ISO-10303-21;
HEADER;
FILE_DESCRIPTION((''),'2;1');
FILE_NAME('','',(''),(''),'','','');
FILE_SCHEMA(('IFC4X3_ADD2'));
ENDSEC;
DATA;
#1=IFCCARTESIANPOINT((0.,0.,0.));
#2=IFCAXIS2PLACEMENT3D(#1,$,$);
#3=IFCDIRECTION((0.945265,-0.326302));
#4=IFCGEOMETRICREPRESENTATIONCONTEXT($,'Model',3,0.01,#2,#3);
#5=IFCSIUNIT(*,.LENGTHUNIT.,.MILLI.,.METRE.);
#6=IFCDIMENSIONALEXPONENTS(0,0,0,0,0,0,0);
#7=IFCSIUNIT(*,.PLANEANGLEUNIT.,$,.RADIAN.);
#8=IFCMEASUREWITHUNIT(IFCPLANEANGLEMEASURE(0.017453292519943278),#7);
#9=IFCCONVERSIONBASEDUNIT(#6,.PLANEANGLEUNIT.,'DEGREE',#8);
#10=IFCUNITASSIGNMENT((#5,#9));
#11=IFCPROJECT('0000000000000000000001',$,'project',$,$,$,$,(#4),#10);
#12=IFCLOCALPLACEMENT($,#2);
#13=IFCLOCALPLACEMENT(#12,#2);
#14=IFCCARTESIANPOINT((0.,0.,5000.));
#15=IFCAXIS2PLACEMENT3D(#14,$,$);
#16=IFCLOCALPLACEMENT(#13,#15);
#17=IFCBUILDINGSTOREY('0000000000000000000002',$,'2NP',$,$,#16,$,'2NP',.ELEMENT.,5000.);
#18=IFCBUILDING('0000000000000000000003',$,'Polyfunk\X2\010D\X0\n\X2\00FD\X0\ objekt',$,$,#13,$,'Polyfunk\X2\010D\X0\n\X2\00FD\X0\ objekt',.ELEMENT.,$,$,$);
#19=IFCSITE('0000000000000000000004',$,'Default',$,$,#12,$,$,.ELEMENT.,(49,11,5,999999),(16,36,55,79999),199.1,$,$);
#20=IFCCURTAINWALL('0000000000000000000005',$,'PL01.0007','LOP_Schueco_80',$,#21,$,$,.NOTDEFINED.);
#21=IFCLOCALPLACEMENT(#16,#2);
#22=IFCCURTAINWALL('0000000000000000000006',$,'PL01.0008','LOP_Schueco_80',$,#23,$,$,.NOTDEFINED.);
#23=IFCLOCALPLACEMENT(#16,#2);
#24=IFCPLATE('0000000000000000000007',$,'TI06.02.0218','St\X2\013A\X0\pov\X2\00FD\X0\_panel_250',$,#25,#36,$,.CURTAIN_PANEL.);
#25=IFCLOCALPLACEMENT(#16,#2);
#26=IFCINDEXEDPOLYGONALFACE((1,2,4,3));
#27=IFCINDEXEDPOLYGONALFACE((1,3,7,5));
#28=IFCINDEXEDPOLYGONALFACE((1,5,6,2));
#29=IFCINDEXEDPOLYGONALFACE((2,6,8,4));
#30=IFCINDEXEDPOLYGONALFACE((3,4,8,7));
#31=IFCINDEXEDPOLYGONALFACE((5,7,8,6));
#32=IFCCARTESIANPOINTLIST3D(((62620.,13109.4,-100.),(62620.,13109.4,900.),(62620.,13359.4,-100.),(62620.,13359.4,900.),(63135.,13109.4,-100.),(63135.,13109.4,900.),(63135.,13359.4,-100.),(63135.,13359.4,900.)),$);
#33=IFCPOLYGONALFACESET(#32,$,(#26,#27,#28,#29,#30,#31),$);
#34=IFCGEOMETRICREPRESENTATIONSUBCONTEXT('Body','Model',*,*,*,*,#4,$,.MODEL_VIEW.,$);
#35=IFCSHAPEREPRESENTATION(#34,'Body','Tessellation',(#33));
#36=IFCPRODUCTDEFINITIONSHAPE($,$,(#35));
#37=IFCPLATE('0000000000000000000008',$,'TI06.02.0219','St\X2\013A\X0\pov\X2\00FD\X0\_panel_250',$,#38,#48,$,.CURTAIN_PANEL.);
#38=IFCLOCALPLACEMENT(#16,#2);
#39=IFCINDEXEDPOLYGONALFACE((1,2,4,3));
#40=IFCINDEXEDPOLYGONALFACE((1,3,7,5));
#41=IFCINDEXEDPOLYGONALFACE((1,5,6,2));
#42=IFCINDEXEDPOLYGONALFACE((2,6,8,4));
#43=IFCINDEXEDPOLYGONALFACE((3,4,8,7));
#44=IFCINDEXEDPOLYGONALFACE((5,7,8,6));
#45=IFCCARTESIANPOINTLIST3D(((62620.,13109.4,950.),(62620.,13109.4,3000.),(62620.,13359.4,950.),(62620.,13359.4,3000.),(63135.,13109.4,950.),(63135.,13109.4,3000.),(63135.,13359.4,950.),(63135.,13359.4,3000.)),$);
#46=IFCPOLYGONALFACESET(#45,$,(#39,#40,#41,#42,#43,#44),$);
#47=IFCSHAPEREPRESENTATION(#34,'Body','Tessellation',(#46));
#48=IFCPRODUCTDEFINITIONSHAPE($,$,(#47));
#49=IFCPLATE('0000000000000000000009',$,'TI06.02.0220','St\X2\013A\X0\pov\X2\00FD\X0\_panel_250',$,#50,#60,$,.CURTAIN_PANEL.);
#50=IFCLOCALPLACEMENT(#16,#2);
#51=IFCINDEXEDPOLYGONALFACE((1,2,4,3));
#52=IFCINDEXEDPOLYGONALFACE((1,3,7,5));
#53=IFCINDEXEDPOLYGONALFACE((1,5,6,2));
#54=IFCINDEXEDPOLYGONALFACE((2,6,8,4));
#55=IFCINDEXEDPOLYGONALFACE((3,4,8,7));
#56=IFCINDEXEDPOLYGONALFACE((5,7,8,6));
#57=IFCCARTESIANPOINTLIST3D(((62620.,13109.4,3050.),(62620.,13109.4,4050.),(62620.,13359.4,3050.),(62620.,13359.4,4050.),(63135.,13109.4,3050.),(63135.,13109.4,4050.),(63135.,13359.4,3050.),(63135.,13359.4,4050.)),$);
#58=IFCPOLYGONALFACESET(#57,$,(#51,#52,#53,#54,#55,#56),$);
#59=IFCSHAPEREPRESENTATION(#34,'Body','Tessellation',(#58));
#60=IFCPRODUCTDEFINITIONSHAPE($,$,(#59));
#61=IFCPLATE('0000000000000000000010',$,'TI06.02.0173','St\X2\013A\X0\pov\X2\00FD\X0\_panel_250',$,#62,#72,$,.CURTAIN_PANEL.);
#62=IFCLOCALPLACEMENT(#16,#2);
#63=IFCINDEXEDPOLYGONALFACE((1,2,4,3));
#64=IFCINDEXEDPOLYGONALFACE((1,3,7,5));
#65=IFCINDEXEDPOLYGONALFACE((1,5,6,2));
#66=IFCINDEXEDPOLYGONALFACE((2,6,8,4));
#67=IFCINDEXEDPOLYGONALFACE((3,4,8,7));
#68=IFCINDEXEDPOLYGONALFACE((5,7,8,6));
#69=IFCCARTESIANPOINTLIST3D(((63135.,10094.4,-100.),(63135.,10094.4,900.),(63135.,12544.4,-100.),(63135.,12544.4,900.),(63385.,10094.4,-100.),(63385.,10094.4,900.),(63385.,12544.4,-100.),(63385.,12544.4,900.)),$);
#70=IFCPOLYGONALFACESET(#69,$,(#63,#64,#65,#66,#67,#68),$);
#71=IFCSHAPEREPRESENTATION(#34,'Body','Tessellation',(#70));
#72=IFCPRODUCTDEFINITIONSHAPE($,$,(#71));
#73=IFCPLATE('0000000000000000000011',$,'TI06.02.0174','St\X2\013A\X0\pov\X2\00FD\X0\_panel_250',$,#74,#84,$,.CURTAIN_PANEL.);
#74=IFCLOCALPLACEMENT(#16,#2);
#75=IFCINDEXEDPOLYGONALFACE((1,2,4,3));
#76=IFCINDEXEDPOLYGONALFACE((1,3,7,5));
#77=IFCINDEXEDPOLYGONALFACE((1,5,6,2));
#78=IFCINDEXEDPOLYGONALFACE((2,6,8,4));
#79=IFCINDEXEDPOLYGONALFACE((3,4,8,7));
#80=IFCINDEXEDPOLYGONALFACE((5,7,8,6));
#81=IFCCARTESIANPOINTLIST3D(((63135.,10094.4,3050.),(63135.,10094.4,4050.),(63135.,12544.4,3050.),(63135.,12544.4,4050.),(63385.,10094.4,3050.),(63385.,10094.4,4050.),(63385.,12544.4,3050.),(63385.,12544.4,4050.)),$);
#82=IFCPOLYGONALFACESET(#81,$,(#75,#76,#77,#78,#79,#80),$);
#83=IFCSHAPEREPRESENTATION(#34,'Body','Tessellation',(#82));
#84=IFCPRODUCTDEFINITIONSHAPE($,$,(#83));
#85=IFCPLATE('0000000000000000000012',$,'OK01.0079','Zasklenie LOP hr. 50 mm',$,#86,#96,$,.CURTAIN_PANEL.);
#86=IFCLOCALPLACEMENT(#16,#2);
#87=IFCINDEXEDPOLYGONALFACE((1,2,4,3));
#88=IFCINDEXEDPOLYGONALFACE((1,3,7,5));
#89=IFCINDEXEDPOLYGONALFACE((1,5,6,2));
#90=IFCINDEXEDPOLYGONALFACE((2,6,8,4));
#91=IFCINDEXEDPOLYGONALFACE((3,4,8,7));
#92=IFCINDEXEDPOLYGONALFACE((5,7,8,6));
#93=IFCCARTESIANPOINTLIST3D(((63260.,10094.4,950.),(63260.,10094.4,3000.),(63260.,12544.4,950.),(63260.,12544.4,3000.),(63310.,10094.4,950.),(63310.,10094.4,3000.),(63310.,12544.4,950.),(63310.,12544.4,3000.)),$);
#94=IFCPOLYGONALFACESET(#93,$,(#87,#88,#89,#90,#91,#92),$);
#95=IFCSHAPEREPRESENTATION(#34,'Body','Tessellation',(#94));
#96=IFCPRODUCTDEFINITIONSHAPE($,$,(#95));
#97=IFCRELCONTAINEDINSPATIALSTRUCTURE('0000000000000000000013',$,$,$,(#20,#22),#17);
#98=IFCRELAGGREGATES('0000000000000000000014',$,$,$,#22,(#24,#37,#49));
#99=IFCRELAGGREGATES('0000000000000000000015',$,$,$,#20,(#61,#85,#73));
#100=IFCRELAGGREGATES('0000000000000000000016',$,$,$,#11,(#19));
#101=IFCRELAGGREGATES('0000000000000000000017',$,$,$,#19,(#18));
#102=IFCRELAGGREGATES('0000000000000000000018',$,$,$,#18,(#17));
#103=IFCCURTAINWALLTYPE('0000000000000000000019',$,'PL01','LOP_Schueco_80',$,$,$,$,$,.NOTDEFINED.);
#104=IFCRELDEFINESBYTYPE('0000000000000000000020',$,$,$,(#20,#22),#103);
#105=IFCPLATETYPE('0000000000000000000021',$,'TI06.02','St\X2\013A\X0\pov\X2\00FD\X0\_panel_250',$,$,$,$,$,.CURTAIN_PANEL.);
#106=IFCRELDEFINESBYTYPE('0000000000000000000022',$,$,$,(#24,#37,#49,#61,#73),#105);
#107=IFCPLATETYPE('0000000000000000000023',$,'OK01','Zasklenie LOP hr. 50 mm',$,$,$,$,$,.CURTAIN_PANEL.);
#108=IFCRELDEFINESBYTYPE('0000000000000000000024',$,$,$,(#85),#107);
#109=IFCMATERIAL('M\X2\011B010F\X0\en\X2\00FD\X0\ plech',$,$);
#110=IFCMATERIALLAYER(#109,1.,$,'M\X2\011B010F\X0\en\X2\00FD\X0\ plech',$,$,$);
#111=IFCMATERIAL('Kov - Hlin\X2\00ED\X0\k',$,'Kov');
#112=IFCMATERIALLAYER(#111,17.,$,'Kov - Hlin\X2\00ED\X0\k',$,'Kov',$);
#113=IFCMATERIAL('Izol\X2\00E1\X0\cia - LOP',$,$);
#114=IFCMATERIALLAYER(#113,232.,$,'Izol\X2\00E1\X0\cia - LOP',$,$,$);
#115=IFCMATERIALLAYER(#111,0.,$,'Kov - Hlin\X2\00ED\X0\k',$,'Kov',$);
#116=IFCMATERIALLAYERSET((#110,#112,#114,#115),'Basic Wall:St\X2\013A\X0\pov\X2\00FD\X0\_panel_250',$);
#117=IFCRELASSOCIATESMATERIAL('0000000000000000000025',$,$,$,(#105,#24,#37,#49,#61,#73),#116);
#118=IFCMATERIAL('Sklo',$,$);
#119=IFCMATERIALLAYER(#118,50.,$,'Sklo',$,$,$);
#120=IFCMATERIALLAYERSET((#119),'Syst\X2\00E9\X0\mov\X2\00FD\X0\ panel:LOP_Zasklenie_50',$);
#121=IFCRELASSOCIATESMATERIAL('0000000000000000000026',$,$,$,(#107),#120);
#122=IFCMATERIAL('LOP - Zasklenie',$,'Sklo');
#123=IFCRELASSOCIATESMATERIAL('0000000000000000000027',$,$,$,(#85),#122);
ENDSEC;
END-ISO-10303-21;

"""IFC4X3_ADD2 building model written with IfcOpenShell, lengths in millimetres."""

from ifc_helpers import new_model, entity, si_unit, converted_unit, direction, frame, frame_2d, origin, origin_2d_with_axis, place, context, subcontext, project, spatial, rectangle, extrude, source, transform, mapped, material, layer, layer_set, layer_usage, type_object, type_shapes, element, aggregate, save


model = new_model("IFC4X3_ADD2")

# Units and contexts
model_context = context("Model", 3, precision=0.01, world=origin(), true_north=direction((0.945265, -0.326302)))
body_context = subcontext(model_context, "Body", "Model", "MODEL_VIEW")
ifc_project = project(units=[si_unit("LENGTHUNIT", "METRE", prefix="MILLI"), converted_unit("PLANEANGLEUNIT", "DEGREE", entity("IfcPlaneAngleMeasure", 0.017453292519943278), si_unit("PLANEANGLEUNIT", "RADIAN"), dimensions=[0, 0, 0, 0, 0, 0, 0])], contexts=[model_context])

# Site, building, storey
site_placement = place(None, origin())
site = spatial("IfcSite", under=ifc_project, at=site_placement, Name="Default", CompositionType="ELEMENT", RefLatitude=(49, 11, 5, 999999), RefLongitude=(16, 36, 55, 79999), RefElevation=199.1)
building_placement = place(site_placement, origin())
building = spatial("IfcBuilding", under=site, at=building_placement, Name="Polyfunkčný objekt", LongName="Polyfunkčný objekt", CompositionType="ELEMENT")
storey_placement = place(building_placement, frame((0.0, 0.0, 5000.0)))
storey = spatial("IfcBuildingStorey", under=building, at=storey_placement, Name="2NP", LongName="2NP", CompositionType="ELEMENT", Elevation=5000.0)

# Curtain wall
curtain_wall_type = type_object("IfcCurtainWallType", Name="PL01", Description="LOP_Schueco_80", PredefinedType="NOTDEFINED")
curtain_wall_1_placement = place(storey_placement, frame((0.0, 0.0, -5000.0)))
curtain_wall_1 = element("IfcCurtainWall", 1, at=curtain_wall_1_placement, inside=storey, type_object=curtain_wall_type, Name="PL01.0007", Description="LOP_Schueco_80", PredefinedType="NOTDEFINED")

# Curtain wall
curtain_wall_2_placement = place(storey_placement, frame((0.0, 0.0, -5000.0)))
curtain_wall_2 = element("IfcCurtainWall", 2, at=curtain_wall_2_placement, inside=storey, type_object=curtain_wall_type, Name="PL01.0008", Description="LOP_Schueco_80", PredefinedType="NOTDEFINED")

# Plates
ifc_material_1 = material(Name="Měďený plech")
ifc_layer_1 = layer(ifc_material_1, 1.0, Name="Měďený plech")
ifc_material_2 = material(Name="Kov - Hliník", Category="Kov")
ifc_layer_2 = layer(ifc_material_2, 17.0, Name="Kov - Hliník", Category="Kov")
ifc_material_3 = material(Name="Izolácia - LOP")
ifc_layer_3 = layer(ifc_material_3, 232.0, Name="Izolácia - LOP")
ifc_layer_4 = layer(ifc_material_2, 0.0, Name="Kov - Hliník", Category="Kov")
ifc_layer_set_1 = layer_set([ifc_layer_1, ifc_layer_2, ifc_layer_3, ifc_layer_4], Name="Basic Wall:Stĺpový_panel_250")
ifc_layer_usage_1 = layer_usage(ifc_layer_set_1, "AXIS2", "NEGATIVE", 125.0)
plate_type_1 = type_object("IfcPlateType", Name="TI06.02", Description="Stĺpový_panel_250", PredefinedType="CURTAIN_PANEL", material=ifc_layer_set_1)
plate_1_placement = place(storey_placement, frame((62620.0, 13234.4, -100.0)))
plate_1 = element("IfcPlate", 3, at=plate_1_placement, type_object=plate_type_1, material=ifc_layer_usage_1, Name="TI06.02.0218", Description="Stĺpový_panel_250", PredefinedType="CURTAIN_PANEL", context=body_context, shape_type="SweptSolid", body=[
    extrude(rectangle(XDim=250.0, YDim=515.0, at=frame_2d((0.0, 0.0), x_axis=(1.0, 0.0))), frame((257.5, 0.0, 0.0), z_axis=(0.0, 0.0, 1.0), x_axis=(0.0, 1.0, 0.0)), (0.0, 0.0, 1.0), 1000.0),
])
ifc_layer_usage_2 = layer_usage(ifc_layer_set_1, "AXIS2", "NEGATIVE", 125.0)
plate_2_placement = place(storey_placement, frame((62620.0, 13234.4, 950.0)))
plate_2 = element("IfcPlate", 4, at=plate_2_placement, type_object=plate_type_1, material=ifc_layer_usage_2, Name="TI06.02.0219", Description="Stĺpový_panel_250", PredefinedType="CURTAIN_PANEL", context=body_context, shape_type="SweptSolid", body=[
    extrude(rectangle(XDim=250.0, YDim=515.0, at=frame_2d((0.0, 0.0), x_axis=(1.0, 0.0))), frame((257.5, 0.0, 0.0), z_axis=(0.0, 0.0, 1.0), x_axis=(0.0, 1.0, 0.0)), (0.0, 0.0, 1.0), 2050.0),
])
ifc_layer_usage_3 = layer_usage(ifc_layer_set_1, "AXIS2", "NEGATIVE", 125.0)
plate_3_placement = place(storey_placement, frame((62620.0, 13234.4, 3050.0)))
plate_3 = element("IfcPlate", 5, at=plate_3_placement, type_object=plate_type_1, material=ifc_layer_usage_3, Name="TI06.02.0220", Description="Stĺpový_panel_250", PredefinedType="CURTAIN_PANEL", context=body_context, shape_type="SweptSolid", body=[
    extrude(rectangle(XDim=250.0, YDim=515.0, at=frame_2d((0.0, 0.0), x_axis=(1.0, 0.0))), frame((257.5, 0.0, 0.0), z_axis=(0.0, 0.0, 1.0), x_axis=(0.0, 1.0, 0.0)), (0.0, 0.0, 1.0), 1000.0),
])
aggregate(curtain_wall_2, [plate_1, plate_2, plate_3])
ifc_layer_usage_4 = layer_usage(ifc_layer_set_1, "AXIS2", "NEGATIVE", 125.0)
plate_4_placement = place(storey_placement, frame((63260.0, 12544.4, -100.0), z_axis=(0.0, 0.0, 1.0), x_axis=(0.0, -1.0, 0.0)))
plate_4 = element("IfcPlate", 6, at=plate_4_placement, type_object=plate_type_1, material=ifc_layer_usage_4, Name="TI06.02.0173", Description="Stĺpový_panel_250", PredefinedType="CURTAIN_PANEL", context=body_context, shape_type="SweptSolid", body=[
    extrude(rectangle(XDim=250.0, YDim=2450.0, at=frame_2d((0.0, 0.0), x_axis=(1.0, 0.0))), frame((1225.0, 0.0, 0.0), z_axis=(0.0, 0.0, 1.0), x_axis=(0.0, 1.0, 0.0)), (0.0, 0.0, 1.0), 1000.0),
])
ifc_layer_usage_5 = layer_usage(ifc_layer_set_1, "AXIS2", "NEGATIVE", 125.0)
plate_5_placement = place(storey_placement, frame((63260.0, 12544.4, 3050.0), z_axis=(0.0, 0.0, 1.0), x_axis=(0.0, -1.0, 0.0)))
plate_5 = element("IfcPlate", 7, at=plate_5_placement, type_object=plate_type_1, material=ifc_layer_usage_5, Name="TI06.02.0174", Description="Stĺpový_panel_250", PredefinedType="CURTAIN_PANEL", context=body_context, shape_type="SweptSolid", body=[
    extrude(rectangle(XDim=250.0, YDim=2450.0, at=frame_2d((0.0, 0.0), x_axis=(1.0, 0.0))), frame((1225.0, 0.0, 0.0), z_axis=(0.0, 0.0, 1.0), x_axis=(0.0, 1.0, 0.0)), (0.0, 0.0, 1.0), 1000.0),
])
ifc_material_4 = material(Name="LOP - Zasklenie", Category="Sklo")
ifc_material_5 = material(Name="Sklo")
ifc_layer_5 = layer(ifc_material_5, 50.0, Name="Sklo")
ifc_layer_set_2 = layer_set([ifc_layer_5], Name="Systémový panel:LOP_Zasklenie_50")
plate_type_2 = type_object("IfcPlateType", Name="OK01", Description="Zasklenie LOP hr. 50 mm", PredefinedType="CURTAIN_PANEL", material=ifc_layer_set_2)
shared_shape_1 = source(origin(), body_context, "Body", "SweptSolid", [
    extrude(rectangle(XDim=50.0, YDim=2450.0, at=origin_2d_with_axis()), frame((0.0, 25.0, 0.0), z_axis=(0.0, 0.0, 1.0), x_axis=(0.0, 1.0, 0.0)), (0.0, 0.0, 1.0), 2050.0),
])
type_shapes(plate_type_2, [shared_shape_1])
plate_6_placement = place(curtain_wall_1_placement, frame((63260.0, 11319.4, 5950.0), z_axis=(0.0, 0.0, 1.0), x_axis=(0.0, -1.0, 0.0)))
plate_6 = element("IfcPlate", 8, at=plate_6_placement, type_object=plate_type_2, material=ifc_material_4, Name="OK01.0079", Description="Zasklenie LOP hr. 50 mm", PredefinedType="CURTAIN_PANEL", context=body_context, shape_type="MappedRepresentation", body=[
    mapped(shared_shape_1, transform((0.0, 0.0, 0.0), scale=1.0)),
])
aggregate(curtain_wall_1, [plate_4, plate_6, plate_5])

save(model, "model.ifc")
